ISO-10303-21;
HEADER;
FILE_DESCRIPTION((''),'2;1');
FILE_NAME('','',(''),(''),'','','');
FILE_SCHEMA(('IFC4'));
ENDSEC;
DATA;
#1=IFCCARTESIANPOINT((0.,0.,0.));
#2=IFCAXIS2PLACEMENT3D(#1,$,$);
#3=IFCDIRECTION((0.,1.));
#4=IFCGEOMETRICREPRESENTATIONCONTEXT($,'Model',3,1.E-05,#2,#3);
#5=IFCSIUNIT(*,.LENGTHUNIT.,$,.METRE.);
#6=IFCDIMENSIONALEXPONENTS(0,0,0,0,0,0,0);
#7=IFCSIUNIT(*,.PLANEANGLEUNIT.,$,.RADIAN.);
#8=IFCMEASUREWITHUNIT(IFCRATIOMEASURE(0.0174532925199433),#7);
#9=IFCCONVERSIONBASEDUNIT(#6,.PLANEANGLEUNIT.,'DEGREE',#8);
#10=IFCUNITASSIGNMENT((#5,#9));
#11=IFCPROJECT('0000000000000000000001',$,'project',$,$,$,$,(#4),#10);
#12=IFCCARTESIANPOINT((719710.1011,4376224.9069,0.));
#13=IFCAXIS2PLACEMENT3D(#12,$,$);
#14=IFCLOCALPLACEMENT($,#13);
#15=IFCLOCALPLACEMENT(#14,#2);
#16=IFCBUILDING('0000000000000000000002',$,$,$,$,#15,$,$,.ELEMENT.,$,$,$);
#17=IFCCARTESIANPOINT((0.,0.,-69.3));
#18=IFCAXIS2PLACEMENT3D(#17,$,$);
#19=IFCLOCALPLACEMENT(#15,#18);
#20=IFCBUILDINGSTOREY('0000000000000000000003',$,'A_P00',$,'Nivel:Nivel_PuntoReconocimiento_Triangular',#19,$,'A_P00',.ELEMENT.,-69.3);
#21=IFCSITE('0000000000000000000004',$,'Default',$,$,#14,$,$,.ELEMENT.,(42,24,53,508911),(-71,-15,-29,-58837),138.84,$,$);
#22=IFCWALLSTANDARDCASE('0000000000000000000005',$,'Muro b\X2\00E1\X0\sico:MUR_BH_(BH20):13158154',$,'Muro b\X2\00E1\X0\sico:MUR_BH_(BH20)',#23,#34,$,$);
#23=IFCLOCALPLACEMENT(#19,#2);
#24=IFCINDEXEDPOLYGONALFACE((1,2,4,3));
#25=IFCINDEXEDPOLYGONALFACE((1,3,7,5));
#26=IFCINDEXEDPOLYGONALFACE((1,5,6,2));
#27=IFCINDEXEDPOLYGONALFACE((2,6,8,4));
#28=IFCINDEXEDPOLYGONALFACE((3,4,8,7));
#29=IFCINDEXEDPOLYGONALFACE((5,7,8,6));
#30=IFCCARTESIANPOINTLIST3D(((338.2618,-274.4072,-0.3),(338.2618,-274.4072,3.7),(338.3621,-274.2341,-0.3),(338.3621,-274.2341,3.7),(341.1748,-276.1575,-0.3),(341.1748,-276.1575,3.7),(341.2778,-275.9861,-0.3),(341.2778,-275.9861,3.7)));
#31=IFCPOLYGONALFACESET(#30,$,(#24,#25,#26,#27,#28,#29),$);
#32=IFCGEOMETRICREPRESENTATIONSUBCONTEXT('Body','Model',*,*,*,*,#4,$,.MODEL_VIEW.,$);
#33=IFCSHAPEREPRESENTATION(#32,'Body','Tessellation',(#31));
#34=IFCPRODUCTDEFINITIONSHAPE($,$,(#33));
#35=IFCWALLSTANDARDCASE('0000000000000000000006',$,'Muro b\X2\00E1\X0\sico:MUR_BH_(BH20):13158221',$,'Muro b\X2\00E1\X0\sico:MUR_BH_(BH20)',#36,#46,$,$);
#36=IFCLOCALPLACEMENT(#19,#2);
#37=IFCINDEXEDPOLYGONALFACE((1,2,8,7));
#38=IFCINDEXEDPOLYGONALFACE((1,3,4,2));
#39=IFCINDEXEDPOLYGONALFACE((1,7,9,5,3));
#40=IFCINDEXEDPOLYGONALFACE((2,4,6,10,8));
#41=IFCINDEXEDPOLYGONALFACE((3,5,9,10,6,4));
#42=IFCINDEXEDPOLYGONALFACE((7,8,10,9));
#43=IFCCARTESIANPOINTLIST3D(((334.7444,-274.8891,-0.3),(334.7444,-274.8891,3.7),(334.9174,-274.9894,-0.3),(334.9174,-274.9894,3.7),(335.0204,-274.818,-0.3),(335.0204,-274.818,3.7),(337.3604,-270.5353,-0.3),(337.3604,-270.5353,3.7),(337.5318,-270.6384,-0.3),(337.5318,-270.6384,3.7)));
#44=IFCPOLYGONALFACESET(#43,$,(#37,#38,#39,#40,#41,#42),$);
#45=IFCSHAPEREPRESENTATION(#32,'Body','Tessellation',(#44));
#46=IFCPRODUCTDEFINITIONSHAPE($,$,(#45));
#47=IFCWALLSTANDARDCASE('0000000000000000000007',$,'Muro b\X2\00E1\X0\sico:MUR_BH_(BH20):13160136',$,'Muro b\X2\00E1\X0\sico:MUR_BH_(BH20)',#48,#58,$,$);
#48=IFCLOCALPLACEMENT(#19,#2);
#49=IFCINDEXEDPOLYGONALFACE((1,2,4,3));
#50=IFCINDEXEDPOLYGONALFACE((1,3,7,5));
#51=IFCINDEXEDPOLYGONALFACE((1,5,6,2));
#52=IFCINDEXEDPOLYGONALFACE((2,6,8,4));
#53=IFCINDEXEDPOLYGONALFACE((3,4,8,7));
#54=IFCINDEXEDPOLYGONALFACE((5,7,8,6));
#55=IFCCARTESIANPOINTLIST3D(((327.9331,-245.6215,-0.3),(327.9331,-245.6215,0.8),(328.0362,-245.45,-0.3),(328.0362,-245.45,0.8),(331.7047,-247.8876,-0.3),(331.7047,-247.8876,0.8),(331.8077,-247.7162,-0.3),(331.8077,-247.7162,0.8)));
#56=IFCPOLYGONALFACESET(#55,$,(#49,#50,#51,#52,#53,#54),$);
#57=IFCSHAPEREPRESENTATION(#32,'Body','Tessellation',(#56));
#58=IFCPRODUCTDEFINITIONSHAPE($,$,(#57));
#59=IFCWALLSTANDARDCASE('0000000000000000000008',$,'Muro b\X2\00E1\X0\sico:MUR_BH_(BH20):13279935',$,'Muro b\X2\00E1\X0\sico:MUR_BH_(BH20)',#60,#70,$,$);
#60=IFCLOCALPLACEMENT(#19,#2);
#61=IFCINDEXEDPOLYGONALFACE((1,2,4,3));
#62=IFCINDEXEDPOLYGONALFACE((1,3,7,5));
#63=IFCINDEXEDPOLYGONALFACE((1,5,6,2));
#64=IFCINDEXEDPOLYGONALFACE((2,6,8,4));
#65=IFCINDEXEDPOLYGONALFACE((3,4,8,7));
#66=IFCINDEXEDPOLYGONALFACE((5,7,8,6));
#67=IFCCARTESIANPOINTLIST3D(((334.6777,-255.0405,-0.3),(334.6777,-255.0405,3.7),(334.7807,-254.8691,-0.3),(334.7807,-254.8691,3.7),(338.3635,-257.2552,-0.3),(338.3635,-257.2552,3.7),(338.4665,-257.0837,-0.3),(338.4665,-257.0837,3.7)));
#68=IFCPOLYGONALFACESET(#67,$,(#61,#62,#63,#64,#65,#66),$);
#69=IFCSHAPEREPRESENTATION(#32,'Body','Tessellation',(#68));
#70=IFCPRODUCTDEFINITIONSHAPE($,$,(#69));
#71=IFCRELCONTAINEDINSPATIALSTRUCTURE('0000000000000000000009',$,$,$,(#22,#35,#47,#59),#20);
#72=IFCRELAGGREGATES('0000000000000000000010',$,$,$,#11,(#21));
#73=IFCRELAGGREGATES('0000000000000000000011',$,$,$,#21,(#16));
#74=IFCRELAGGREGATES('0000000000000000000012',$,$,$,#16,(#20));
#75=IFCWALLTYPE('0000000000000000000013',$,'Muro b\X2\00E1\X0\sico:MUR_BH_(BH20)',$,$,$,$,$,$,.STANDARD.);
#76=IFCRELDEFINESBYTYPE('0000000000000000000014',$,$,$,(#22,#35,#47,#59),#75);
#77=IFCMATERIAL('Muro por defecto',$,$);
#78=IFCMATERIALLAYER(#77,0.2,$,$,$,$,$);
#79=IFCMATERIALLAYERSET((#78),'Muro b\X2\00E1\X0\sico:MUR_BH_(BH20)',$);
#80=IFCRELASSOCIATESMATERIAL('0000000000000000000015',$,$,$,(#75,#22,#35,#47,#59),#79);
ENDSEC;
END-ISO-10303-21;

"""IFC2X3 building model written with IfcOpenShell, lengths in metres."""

from ifc_helpers import new_model, entity, si_unit, converted_unit, direction, frame, frame_2d, origin, place, context, subcontext, project, spatial, polyline, rectangle, outline, extrude, material, layer, layer_set, layer_usage, type_object, element, save


model = new_model("IFC2X3")

# Units and contexts
model_context = context("Model", 3, precision=1e-05, world=origin(), true_north=direction((0.0, 1.0)))
body_context = subcontext(model_context, "Body", "Model", "MODEL_VIEW")
ifc_project = project(units=[si_unit("LENGTHUNIT", "METRE"), converted_unit("PLANEANGLEUNIT", "DEGREE", entity("IfcRatioMeasure", 0.0174532925199433), si_unit("PLANEANGLEUNIT", "RADIAN"), dimensions=[0, 0, 0, 0, 0, 0, 0])], contexts=[model_context])

# Site, building, storey
site_placement = place(None, frame((719710.1011, 4376224.9069, 0.0)))
site = spatial("IfcSite", under=ifc_project, at=site_placement, Name="Default", CompositionType="ELEMENT", RefLatitude=(42, 24, 53, 508911), RefLongitude=(-71, -15, -29, -58837), RefElevation=138.84)
building_placement = place(site_placement, origin())
building = spatial("IfcBuilding", under=site, at=building_placement, CompositionType="ELEMENT")
storey_placement = place(building_placement, frame((0.0, 0.0, -69.3)))
storey = spatial("IfcBuildingStorey", under=building, at=storey_placement, Name="A_P00", ObjectType="Nivel:Nivel_PuntoReconocimiento_Triangular", LongName="A_P00", CompositionType="ELEMENT", Elevation=-69.3)

# Shared definitions
ifc_material_1 = material(Name="Muro por defecto")
ifc_layer = layer(ifc_material_1, 0.2)
ifc_layer_set = layer_set([ifc_layer], Name="Muro básico:MUR_BH_(BH20)")
wall_type = type_object("IfcWallType", Name="Muro básico:MUR_BH_(BH20)", PredefinedType="STANDARD", material=ifc_layer_set)

# Walls
ifc_layer_usage_1 = layer_usage(ifc_layer_set, "AXIS2", "NEGATIVE", 0.1)
wall_1_placement = place(storey_placement, frame((338.3106, -274.3198, -0.3), z_axis=(0.0, 0.0, 1.0), x_axis=(0.857167, -0.515038, 0.0)))
element("IfcWallStandardCase", 1, at=wall_1_placement, inside=storey, type_object=wall_type, material=ifc_layer_usage_1, Name="Muro básico:MUR_BH_(BH20):13158154", ObjectType="Muro básico:MUR_BH_(BH20)", context=body_context, shape_type="SweptSolid", body=[
    extrude(outline(polyline([(3.4016, -0.1), (3.4016, 0.1), (0.0, 0.1), (0.0031, -0.1), (3.4016, -0.1)])), origin(), (0.0, 0.0, 1.0), 4.0),
])
ifc_layer_usage_2 = layer_usage(ifc_layer_set, "AXIS2", "NEGATIVE", 0.1)
wall_2_placement = place(storey_placement, frame((337.4461, -270.5869, -0.3), z_axis=(0.0, 0.0, 1.0), x_axis=(-0.515038, -0.857167, 0.0)))
element("IfcWallStandardCase", 2, at=wall_2_placement, inside=storey, type_object=wall_type, material=ifc_layer_usage_2, Name="Muro básico:MUR_BH_(BH20):13158221", ObjectType="Muro básico:MUR_BH_(BH20)", context=body_context, shape_type="SweptSolid", body=[
    extrude(outline(polyline([(5.0792, -0.1), (5.0761, 0.1), (4.8761, 0.1), (0.0, 0.1), (0.0, -0.1), (5.0792, -0.1)])), origin(), (0.0, 0.0, 1.0), 4.0),
])
ifc_layer_usage_3 = layer_usage(ifc_layer_set, "AXIS2", "NEGATIVE", 0.1)
wall_3_placement = place(storey_placement, frame((331.7562, -247.8019, -0.3), z_axis=(0.0, 0.0, 1.0), x_axis=(-0.857167, 0.515038, 0.0)))
element("IfcWallStandardCase", 3, at=wall_3_placement, inside=storey, type_object=wall_type, material=ifc_layer_usage_3, Name="Muro básico:MUR_BH_(BH20):13160136", ObjectType="Muro básico:MUR_BH_(BH20)", context=body_context, shape_type="SweptSolid", body=[
    extrude(rectangle(XDim=4.4, YDim=0.2, at=frame_2d((2.2, 0.0), x_axis=(-1.0, 0.0))), origin(), (0.0, 0.0, 1.0), 1.1),
])
ifc_layer_usage_4 = layer_usage(ifc_layer_set, "AXIS2", "NEGATIVE", 0.1)
wall_4_placement = place(storey_placement, frame((334.7292, -254.9548, -0.3), z_axis=(0.0, 0.0, 1.0), x_axis=(0.857167, -0.515038, 0.0)))
element("IfcWallStandardCase", 4, at=wall_4_placement, inside=storey, type_object=wall_type, material=ifc_layer_usage_4, Name="Muro básico:MUR_BH_(BH20):13279935", ObjectType="Muro básico:MUR_BH_(BH20)", context=body_context, shape_type="SweptSolid", body=[
    extrude(rectangle(XDim=4.3, YDim=0.2, at=frame_2d((2.15, 0.0), x_axis=(-1.0, 0.0))), origin(), (0.0, 0.0, 1.0), 4.0),
])

save(model, "model.ifc")
